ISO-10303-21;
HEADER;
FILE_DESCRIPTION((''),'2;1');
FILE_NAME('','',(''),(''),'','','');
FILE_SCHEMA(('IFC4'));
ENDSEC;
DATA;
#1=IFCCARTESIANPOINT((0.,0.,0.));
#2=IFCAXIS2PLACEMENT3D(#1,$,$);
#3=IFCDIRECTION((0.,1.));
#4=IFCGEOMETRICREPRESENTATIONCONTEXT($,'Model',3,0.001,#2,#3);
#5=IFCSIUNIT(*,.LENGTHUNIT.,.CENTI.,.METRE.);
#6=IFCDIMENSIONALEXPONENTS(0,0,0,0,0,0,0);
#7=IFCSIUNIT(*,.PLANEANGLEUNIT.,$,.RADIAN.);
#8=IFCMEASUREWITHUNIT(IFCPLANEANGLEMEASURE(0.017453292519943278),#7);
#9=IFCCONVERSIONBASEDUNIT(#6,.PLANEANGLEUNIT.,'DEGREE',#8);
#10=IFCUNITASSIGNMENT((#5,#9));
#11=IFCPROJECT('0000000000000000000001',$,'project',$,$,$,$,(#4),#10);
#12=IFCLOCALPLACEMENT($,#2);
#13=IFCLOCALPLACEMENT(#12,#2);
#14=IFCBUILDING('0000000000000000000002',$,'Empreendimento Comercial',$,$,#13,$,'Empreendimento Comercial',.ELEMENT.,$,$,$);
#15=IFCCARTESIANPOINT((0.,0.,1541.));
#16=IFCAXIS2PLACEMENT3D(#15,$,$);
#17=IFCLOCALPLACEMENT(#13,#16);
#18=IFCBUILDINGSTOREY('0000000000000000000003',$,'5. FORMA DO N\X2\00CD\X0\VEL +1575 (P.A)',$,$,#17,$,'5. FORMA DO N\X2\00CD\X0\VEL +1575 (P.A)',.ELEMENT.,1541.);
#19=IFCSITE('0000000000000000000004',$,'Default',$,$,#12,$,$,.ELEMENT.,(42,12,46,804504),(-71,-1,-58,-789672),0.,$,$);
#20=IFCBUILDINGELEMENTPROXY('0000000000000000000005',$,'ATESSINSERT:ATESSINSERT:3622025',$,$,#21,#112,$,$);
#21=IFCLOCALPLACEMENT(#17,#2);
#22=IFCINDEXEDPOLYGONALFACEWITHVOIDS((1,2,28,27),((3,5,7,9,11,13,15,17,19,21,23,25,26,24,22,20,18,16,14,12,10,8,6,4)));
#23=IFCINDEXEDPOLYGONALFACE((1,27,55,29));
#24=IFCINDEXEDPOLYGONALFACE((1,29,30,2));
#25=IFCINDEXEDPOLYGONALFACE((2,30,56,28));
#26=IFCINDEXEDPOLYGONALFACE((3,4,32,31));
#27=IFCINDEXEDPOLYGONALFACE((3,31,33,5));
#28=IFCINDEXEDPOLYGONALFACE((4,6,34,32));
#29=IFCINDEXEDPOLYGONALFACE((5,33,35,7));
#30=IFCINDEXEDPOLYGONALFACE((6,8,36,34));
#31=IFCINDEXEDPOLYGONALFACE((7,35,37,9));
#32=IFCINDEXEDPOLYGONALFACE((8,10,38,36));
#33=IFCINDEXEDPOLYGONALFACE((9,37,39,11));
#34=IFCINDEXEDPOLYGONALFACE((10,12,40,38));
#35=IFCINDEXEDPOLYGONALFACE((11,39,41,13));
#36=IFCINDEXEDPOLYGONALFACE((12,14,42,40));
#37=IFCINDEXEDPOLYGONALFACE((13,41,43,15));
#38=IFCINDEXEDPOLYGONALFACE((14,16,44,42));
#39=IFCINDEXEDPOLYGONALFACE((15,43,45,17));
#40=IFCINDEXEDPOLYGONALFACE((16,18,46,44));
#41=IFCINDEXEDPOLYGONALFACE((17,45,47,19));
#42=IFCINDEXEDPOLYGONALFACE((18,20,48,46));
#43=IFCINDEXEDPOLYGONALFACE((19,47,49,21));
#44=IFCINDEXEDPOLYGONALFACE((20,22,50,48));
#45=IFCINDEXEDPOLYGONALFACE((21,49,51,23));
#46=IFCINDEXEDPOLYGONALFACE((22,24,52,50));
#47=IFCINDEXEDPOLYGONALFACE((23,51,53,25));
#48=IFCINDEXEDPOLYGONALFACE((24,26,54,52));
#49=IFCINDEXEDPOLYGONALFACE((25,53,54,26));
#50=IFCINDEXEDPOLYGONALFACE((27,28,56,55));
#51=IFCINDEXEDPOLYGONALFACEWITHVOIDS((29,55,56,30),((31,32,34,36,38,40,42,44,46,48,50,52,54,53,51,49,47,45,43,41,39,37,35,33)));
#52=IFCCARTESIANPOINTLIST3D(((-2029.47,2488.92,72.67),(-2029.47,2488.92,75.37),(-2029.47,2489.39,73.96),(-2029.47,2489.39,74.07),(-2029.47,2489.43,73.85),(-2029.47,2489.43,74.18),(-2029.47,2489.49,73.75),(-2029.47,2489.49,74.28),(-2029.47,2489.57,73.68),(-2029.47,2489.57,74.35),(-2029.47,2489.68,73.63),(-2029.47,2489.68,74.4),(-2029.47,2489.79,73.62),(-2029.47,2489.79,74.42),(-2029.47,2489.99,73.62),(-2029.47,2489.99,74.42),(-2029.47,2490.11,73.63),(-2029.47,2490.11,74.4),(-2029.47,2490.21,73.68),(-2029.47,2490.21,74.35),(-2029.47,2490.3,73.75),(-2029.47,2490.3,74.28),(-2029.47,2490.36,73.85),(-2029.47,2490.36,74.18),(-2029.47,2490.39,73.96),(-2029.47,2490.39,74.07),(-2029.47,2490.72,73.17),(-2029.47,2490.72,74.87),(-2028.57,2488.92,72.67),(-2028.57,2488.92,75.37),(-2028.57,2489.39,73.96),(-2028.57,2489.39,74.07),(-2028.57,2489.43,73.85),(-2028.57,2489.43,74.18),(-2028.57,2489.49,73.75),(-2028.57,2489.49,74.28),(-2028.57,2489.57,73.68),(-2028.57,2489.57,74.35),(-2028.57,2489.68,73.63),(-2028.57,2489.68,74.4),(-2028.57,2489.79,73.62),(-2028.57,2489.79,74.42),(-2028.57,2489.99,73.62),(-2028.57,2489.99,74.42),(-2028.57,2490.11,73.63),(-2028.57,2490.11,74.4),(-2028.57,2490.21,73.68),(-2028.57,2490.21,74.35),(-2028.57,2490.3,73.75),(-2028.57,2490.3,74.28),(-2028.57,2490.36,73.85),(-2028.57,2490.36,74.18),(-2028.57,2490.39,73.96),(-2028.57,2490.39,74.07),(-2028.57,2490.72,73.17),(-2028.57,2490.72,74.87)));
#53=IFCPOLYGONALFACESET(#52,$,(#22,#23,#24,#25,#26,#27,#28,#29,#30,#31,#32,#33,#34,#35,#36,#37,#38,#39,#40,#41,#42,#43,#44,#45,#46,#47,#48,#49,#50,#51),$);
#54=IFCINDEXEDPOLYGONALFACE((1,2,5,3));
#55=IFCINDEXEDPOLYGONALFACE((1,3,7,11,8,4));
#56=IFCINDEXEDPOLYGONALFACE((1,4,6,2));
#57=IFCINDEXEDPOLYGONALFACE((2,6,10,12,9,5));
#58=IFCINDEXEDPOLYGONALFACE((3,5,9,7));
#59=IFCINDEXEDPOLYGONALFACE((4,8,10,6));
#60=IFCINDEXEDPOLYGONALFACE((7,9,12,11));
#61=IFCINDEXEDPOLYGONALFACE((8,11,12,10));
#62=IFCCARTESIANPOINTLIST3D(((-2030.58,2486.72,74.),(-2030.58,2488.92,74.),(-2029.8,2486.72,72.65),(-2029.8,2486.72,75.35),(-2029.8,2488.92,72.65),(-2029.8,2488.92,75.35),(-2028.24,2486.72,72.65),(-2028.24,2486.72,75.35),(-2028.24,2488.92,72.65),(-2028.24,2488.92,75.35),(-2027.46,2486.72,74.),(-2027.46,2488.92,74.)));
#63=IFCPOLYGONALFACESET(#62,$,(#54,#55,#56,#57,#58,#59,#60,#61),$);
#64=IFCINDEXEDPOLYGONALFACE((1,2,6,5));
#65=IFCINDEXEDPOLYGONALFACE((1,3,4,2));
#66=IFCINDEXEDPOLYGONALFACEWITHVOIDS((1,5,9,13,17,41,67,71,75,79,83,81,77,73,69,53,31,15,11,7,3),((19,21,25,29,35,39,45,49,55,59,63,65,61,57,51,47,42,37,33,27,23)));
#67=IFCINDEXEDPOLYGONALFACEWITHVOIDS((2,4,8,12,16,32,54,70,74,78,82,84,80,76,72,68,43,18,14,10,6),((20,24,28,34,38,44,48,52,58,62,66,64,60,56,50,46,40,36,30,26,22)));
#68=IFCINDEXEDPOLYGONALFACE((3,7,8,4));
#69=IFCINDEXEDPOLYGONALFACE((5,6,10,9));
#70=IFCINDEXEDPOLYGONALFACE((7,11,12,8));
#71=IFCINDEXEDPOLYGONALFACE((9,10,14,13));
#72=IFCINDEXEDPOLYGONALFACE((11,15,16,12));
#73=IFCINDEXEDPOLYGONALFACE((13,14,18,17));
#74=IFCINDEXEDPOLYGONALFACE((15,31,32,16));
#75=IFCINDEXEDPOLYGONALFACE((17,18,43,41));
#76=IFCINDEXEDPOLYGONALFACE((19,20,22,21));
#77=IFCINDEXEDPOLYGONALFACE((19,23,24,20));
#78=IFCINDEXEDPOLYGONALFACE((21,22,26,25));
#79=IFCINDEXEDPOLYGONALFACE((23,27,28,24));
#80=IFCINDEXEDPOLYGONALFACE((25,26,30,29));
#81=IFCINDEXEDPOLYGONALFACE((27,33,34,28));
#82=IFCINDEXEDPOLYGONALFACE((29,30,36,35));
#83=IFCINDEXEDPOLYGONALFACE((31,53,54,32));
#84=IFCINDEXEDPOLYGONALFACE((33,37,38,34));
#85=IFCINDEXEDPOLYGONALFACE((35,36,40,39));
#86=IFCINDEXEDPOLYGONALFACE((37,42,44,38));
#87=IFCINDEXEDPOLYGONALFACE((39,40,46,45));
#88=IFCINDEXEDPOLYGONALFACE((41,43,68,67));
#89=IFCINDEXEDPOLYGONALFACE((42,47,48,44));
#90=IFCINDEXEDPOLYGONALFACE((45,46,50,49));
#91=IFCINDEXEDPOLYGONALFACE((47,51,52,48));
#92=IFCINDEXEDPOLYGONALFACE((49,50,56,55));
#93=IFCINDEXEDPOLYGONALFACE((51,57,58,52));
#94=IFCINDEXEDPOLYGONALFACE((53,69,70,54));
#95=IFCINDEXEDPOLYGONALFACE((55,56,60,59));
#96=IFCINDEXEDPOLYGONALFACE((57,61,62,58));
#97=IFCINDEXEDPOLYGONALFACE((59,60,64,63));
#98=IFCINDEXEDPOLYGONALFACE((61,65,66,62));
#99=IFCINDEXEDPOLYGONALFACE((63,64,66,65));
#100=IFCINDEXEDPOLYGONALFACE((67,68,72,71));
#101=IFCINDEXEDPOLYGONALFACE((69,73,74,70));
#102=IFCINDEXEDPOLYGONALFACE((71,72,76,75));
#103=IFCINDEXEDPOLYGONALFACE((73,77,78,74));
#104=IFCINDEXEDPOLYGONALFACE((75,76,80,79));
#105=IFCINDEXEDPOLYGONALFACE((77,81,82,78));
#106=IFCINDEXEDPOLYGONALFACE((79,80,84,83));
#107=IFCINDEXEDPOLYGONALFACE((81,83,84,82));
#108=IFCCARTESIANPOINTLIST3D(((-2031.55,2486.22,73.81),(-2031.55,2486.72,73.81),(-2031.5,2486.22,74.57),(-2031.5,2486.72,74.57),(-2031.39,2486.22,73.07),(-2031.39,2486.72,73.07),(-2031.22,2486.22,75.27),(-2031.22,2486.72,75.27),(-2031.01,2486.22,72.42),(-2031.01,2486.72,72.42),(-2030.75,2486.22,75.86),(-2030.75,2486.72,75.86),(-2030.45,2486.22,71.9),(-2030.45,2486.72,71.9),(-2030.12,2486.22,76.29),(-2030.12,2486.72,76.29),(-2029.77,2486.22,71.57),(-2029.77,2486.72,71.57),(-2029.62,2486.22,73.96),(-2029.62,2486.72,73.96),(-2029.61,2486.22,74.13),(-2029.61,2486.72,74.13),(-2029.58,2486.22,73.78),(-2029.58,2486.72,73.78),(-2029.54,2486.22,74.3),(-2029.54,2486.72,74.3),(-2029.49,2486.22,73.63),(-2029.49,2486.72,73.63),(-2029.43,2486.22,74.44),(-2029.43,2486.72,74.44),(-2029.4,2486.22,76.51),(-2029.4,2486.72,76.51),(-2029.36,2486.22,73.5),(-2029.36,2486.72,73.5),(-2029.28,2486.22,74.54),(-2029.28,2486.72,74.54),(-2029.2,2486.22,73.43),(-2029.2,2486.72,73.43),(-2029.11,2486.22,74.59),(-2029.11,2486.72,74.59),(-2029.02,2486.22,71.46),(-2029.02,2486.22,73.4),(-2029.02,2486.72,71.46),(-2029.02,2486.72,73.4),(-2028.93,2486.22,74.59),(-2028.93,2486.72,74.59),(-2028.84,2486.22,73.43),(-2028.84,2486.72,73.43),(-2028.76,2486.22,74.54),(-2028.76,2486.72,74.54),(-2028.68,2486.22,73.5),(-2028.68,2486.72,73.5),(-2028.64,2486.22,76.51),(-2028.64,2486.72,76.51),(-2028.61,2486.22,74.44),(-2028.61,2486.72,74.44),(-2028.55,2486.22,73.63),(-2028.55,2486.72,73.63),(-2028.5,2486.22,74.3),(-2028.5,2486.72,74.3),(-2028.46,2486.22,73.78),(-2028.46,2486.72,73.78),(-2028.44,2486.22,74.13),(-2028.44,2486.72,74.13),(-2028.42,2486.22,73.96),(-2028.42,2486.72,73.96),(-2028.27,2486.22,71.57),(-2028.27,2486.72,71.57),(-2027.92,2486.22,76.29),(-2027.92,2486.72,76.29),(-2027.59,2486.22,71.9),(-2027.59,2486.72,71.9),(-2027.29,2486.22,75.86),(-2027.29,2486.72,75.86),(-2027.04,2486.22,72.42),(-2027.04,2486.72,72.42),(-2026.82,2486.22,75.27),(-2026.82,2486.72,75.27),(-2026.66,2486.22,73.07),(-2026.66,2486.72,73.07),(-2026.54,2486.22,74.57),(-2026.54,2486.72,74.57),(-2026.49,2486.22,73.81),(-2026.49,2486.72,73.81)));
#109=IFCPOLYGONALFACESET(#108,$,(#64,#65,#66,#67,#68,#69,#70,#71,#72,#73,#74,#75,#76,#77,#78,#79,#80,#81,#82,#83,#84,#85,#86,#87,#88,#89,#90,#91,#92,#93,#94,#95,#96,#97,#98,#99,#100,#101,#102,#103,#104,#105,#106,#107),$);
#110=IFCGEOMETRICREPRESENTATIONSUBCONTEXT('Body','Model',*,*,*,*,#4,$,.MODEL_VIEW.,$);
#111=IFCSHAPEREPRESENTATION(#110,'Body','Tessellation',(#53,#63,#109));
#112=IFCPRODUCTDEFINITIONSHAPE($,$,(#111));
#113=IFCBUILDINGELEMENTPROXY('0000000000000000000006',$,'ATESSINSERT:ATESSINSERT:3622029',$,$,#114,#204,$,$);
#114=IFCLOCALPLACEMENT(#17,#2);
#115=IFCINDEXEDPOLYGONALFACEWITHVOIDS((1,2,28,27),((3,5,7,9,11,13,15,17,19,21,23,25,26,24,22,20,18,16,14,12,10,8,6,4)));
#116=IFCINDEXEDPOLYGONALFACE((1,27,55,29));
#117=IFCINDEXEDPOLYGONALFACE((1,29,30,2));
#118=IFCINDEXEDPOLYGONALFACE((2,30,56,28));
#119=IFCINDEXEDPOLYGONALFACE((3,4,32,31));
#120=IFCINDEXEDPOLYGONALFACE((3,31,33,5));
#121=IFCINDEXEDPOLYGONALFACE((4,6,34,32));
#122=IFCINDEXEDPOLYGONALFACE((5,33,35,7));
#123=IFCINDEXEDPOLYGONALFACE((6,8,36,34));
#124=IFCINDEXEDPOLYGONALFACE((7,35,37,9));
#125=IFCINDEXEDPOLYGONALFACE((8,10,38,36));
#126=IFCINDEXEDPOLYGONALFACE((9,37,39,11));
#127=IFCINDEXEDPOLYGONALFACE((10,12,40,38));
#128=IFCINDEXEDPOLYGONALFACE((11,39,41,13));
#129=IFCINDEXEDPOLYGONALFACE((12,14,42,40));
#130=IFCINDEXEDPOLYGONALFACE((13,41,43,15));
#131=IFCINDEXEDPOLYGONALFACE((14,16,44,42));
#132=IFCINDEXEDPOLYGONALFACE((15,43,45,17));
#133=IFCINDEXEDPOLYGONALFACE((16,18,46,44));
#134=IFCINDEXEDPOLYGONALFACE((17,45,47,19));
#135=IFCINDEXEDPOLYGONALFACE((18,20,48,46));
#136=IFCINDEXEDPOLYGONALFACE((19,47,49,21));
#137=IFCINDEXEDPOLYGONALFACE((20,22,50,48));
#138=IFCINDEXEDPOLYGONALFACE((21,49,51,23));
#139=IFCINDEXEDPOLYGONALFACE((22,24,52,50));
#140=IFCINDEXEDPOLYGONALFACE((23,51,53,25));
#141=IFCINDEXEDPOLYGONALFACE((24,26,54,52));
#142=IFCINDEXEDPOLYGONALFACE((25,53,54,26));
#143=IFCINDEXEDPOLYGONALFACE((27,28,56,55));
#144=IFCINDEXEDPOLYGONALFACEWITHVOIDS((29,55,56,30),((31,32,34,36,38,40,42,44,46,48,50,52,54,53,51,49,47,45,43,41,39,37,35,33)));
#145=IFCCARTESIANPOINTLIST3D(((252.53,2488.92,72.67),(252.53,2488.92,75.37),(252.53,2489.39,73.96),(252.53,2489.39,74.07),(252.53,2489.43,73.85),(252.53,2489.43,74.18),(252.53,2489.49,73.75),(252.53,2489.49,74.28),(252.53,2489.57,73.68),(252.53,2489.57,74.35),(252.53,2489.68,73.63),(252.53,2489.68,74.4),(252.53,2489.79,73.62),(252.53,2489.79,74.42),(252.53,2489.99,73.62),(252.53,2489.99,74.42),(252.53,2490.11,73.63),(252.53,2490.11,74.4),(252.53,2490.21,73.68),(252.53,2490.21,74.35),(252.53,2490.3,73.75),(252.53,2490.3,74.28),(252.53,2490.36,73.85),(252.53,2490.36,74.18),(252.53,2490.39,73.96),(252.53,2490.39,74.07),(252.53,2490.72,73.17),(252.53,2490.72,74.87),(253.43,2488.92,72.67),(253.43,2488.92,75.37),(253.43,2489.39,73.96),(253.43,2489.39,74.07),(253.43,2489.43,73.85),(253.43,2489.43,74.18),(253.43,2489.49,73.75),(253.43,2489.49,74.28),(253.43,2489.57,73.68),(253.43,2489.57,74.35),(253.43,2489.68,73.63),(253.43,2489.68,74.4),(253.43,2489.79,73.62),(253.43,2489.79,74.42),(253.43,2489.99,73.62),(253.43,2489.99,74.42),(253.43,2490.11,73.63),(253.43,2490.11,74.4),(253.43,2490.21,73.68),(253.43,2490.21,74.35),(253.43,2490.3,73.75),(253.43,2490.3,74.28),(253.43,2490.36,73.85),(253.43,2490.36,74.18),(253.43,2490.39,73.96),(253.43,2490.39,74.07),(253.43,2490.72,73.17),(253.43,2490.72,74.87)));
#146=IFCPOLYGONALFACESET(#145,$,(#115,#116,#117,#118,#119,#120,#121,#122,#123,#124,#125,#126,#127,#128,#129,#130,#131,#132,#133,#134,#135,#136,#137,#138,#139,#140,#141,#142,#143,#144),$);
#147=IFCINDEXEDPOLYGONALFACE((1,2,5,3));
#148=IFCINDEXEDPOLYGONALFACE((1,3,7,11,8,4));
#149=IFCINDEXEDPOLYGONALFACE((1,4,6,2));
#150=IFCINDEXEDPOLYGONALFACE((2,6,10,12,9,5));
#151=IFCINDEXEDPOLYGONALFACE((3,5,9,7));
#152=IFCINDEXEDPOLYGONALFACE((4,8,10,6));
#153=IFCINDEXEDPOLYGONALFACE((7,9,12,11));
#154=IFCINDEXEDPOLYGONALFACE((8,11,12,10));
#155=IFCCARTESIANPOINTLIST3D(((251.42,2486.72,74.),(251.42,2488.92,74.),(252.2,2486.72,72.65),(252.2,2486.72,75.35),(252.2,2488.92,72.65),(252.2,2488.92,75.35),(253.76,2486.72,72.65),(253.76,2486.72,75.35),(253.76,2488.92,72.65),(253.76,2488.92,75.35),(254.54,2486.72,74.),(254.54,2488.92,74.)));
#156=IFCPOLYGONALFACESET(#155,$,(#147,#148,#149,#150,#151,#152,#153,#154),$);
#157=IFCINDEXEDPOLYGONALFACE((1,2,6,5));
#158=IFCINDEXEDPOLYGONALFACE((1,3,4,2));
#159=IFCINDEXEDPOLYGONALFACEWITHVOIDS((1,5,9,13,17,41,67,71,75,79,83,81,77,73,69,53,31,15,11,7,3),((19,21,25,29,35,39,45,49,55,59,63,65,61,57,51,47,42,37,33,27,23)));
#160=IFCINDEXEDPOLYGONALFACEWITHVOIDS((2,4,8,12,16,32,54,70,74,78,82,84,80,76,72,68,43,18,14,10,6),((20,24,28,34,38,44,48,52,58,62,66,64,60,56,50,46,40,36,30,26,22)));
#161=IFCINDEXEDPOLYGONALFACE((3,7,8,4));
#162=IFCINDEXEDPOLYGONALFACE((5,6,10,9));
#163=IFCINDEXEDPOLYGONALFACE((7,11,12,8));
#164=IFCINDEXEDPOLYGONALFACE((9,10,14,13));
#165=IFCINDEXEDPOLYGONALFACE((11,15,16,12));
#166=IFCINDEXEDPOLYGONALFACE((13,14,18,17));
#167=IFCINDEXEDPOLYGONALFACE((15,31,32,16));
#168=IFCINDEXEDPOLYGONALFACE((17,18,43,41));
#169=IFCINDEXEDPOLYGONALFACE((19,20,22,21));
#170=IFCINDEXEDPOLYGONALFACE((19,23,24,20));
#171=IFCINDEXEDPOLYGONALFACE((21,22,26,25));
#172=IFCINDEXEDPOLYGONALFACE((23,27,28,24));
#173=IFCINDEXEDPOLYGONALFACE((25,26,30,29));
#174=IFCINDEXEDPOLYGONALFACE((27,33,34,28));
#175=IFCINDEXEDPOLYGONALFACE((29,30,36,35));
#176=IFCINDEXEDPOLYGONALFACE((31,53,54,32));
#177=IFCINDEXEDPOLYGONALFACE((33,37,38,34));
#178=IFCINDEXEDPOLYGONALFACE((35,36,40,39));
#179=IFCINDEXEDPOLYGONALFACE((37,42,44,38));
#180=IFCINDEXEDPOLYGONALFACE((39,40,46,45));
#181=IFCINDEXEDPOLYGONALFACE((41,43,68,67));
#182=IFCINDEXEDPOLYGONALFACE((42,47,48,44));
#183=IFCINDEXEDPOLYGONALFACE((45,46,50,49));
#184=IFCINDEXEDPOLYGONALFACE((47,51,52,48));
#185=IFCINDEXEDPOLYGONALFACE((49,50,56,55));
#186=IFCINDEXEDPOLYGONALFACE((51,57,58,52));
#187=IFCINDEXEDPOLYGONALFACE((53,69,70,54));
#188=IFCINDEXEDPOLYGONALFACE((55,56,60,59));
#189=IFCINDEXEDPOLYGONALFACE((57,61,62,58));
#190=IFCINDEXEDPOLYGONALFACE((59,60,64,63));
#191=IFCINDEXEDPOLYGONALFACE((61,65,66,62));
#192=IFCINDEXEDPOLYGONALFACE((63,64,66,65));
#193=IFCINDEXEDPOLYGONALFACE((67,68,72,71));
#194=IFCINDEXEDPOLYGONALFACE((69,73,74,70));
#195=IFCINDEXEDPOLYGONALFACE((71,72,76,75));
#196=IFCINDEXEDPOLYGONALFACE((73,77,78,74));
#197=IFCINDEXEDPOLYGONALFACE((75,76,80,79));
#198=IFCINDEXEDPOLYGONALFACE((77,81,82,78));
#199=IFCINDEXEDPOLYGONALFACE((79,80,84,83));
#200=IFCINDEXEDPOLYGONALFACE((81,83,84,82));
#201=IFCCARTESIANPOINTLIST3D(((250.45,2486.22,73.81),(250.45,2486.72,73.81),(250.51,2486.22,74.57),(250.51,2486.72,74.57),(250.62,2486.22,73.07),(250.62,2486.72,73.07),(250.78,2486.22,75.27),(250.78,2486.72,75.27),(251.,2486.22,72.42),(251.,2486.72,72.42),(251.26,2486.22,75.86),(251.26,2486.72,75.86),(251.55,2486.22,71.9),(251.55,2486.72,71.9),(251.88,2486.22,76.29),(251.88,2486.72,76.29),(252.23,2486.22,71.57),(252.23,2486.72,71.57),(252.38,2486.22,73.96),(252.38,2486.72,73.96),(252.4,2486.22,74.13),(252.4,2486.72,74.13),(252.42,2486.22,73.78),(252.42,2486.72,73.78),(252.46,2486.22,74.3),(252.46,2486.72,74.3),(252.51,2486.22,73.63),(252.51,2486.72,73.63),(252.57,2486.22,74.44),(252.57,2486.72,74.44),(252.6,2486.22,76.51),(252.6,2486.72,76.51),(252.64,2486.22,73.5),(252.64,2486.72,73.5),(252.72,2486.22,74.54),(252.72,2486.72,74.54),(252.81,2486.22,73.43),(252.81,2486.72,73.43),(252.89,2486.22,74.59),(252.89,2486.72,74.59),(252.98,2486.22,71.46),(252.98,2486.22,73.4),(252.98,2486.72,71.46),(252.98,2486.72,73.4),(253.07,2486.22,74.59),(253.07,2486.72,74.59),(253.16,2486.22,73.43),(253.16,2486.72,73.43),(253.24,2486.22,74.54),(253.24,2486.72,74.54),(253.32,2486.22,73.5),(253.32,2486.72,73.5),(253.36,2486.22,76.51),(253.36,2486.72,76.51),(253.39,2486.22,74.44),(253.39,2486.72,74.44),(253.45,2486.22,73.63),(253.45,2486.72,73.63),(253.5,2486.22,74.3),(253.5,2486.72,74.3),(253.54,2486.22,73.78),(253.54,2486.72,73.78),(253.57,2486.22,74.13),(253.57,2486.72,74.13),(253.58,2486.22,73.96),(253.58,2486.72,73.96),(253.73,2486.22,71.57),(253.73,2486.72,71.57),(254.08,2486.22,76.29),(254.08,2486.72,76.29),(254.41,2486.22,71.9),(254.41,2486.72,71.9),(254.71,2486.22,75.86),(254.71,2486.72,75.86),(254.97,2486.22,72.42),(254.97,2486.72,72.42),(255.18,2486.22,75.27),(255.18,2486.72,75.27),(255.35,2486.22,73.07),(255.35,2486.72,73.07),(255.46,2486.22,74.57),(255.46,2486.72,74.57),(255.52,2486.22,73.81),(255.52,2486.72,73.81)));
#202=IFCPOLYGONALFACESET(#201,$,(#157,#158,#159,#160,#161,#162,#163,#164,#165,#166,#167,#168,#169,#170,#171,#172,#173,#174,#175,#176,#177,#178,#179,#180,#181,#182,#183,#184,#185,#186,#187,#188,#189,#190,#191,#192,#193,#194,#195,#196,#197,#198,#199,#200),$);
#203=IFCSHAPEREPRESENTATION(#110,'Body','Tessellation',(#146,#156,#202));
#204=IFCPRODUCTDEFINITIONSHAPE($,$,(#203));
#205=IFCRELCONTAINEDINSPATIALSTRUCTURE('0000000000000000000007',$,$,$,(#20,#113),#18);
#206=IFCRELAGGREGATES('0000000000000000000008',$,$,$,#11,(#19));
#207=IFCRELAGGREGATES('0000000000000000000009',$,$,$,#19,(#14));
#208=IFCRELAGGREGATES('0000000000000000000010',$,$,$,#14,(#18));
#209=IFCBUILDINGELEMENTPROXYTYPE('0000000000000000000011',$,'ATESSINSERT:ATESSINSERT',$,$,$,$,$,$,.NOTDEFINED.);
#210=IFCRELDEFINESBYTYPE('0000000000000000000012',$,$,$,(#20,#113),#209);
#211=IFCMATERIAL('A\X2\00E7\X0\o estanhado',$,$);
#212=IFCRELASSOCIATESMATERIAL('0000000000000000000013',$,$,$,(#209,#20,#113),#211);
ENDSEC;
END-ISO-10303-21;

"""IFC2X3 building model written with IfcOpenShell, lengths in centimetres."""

from ifc_helpers import new_model, entity, si_unit, converted_unit, direction, frame, frame_2d, origin, place, context, subcontext, project, spatial, polyline, circle_curve, parameter, trimmed, segment, composite_curve, hollow_circle, outline, extrude, source, transform, mapped, material, type_object, type_shapes, element, save


model = new_model("IFC2X3")

# Units and contexts
model_context = context("Model", 3, precision=0.001, world=origin(), true_north=direction((0.0, 1.0)))
body_context = subcontext(model_context, "Body", "Model", "MODEL_VIEW")
ifc_project = project(units=[si_unit("LENGTHUNIT", "METRE", prefix="CENTI"), converted_unit("PLANEANGLEUNIT", "DEGREE", entity("IfcPlaneAngleMeasure", 0.017453292519943278), si_unit("PLANEANGLEUNIT", "RADIAN"), dimensions=[0, 0, 0, 0, 0, 0, 0])], contexts=[model_context])

# Site, building, storey
site_placement = place(None, origin())
site = spatial("IfcSite", under=ifc_project, at=site_placement, Name="Default", CompositionType="ELEMENT", RefLatitude=(42, 12, 46, 804504), RefLongitude=(-71, -1, -58, -789672), RefElevation=0.0)
building_placement = place(site_placement, origin())
building = spatial("IfcBuilding", under=site, at=building_placement, Name="Empreendimento Comercial", LongName="Empreendimento Comercial", CompositionType="ELEMENT")
storey_placement = place(building_placement, frame((0.0, 0.0, 1541.0)))
storey = spatial("IfcBuildingStorey", under=building, at=storey_placement, Name="5. FORMA DO NÍVEL +1575 (P.A)", LongName="5. FORMA DO NÍVEL +1575 (P.A)", CompositionType="ELEMENT", Elevation=1541.0)

# Building element proxies
ifc_material_1 = material(Name="Aço estanhado")
building_element_proxy_type_1 = type_object("IfcBuildingElementProxyType", Name="ATESSINSERT:ATESSINSERT", PredefinedType="NOTDEFINED", material=ifc_material_1)
shared_shape_1 = source(origin(), body_context, "Body", "SweptSolid", [
    extrude(outline(polyline([(-1.35, -0.9), (1.35, -0.9), (0.85, 0.9), (-0.85, 0.9), (-1.35, -0.9)]), holes=[composite_curve([segment(trimmed(circle_curve(frame_2d((0.0, 0.17), x_axis=(1.0, 0.0)), 0.4), [parameter(0.0)], [parameter(180.0)], True, "PARAMETER"), False, "CONTINUOUS"), segment(polyline([(0.4, 0.17), (0.4, -0.03)]), True, "CONTINUOUS"), segment(trimmed(circle_curve(frame_2d((0.0, -0.03), x_axis=(1.0, 0.0)), 0.4), [parameter(180.0)], [parameter(0.0)], True, "PARAMETER"), False, "CONTINUOUS"), segment(polyline([(-0.4, -0.03), (-0.4, 0.17)]), True, "CONTINUOUS")], self_intersect=False)]), frame((-1.4, -0.45, 30.02), z_axis=(0.0, 1.0, 0.0), x_axis=(0.0, 0.0, 1.0)), (0.0, 0.0, 1.0), 0.9),
    extrude(outline(polyline([(-0.78, -1.35), (0.78, -1.35), (1.56, 0.0), (0.78, 1.35), (-0.78, 1.35), (-1.56, 0.0), (-0.78, -1.35)])), frame((-4.5, 0.0, 30.0), z_axis=(1.0, 0.0, 0.0), x_axis=(0.0, 1.0, 0.0)), (0.0, 0.0, 1.0), 2.2),
    extrude(hollow_circle(Radius=2.54, WallThickness=1.94, at=frame_2d((0.0, 0.0), x_axis=(1.0, 0.0))), frame((-5.0, 0.0, 30.0), z_axis=(1.0, 0.0, 0.0), x_axis=(0.0, 0.0, -1.0)), (0.0, 0.0, 1.0), 0.5),
])
type_shapes(building_element_proxy_type_1, [shared_shape_1])
for number, where, z_axis, x_axis, name in (
    (1, (-2029.02, 2491.22, 44.0), (0.0, 0.0, 1.0), (0.0, 1.0, 0.0), "ATESSINSERT:ATESSINSERT:3622025"),
    (2, (252.98, 2491.22, 44.0), (0.0, 0.0, 1.0), (0.0, 1.0, 0.0), "ATESSINSERT:ATESSINSERT:3622029"),
):
    element("IfcBuildingElementProxy", number, at=place(storey_placement, frame(where, z_axis=z_axis, x_axis=x_axis)), inside=storey, type_object=building_element_proxy_type_1, material=ifc_material_1, Name=name, context=body_context, shape_type="MappedRepresentation", body=[
        mapped(shared_shape_1, transform((0.0, 0.0, 0.0), scale=1.0)),
    ])

save(model, "model.ifc")
